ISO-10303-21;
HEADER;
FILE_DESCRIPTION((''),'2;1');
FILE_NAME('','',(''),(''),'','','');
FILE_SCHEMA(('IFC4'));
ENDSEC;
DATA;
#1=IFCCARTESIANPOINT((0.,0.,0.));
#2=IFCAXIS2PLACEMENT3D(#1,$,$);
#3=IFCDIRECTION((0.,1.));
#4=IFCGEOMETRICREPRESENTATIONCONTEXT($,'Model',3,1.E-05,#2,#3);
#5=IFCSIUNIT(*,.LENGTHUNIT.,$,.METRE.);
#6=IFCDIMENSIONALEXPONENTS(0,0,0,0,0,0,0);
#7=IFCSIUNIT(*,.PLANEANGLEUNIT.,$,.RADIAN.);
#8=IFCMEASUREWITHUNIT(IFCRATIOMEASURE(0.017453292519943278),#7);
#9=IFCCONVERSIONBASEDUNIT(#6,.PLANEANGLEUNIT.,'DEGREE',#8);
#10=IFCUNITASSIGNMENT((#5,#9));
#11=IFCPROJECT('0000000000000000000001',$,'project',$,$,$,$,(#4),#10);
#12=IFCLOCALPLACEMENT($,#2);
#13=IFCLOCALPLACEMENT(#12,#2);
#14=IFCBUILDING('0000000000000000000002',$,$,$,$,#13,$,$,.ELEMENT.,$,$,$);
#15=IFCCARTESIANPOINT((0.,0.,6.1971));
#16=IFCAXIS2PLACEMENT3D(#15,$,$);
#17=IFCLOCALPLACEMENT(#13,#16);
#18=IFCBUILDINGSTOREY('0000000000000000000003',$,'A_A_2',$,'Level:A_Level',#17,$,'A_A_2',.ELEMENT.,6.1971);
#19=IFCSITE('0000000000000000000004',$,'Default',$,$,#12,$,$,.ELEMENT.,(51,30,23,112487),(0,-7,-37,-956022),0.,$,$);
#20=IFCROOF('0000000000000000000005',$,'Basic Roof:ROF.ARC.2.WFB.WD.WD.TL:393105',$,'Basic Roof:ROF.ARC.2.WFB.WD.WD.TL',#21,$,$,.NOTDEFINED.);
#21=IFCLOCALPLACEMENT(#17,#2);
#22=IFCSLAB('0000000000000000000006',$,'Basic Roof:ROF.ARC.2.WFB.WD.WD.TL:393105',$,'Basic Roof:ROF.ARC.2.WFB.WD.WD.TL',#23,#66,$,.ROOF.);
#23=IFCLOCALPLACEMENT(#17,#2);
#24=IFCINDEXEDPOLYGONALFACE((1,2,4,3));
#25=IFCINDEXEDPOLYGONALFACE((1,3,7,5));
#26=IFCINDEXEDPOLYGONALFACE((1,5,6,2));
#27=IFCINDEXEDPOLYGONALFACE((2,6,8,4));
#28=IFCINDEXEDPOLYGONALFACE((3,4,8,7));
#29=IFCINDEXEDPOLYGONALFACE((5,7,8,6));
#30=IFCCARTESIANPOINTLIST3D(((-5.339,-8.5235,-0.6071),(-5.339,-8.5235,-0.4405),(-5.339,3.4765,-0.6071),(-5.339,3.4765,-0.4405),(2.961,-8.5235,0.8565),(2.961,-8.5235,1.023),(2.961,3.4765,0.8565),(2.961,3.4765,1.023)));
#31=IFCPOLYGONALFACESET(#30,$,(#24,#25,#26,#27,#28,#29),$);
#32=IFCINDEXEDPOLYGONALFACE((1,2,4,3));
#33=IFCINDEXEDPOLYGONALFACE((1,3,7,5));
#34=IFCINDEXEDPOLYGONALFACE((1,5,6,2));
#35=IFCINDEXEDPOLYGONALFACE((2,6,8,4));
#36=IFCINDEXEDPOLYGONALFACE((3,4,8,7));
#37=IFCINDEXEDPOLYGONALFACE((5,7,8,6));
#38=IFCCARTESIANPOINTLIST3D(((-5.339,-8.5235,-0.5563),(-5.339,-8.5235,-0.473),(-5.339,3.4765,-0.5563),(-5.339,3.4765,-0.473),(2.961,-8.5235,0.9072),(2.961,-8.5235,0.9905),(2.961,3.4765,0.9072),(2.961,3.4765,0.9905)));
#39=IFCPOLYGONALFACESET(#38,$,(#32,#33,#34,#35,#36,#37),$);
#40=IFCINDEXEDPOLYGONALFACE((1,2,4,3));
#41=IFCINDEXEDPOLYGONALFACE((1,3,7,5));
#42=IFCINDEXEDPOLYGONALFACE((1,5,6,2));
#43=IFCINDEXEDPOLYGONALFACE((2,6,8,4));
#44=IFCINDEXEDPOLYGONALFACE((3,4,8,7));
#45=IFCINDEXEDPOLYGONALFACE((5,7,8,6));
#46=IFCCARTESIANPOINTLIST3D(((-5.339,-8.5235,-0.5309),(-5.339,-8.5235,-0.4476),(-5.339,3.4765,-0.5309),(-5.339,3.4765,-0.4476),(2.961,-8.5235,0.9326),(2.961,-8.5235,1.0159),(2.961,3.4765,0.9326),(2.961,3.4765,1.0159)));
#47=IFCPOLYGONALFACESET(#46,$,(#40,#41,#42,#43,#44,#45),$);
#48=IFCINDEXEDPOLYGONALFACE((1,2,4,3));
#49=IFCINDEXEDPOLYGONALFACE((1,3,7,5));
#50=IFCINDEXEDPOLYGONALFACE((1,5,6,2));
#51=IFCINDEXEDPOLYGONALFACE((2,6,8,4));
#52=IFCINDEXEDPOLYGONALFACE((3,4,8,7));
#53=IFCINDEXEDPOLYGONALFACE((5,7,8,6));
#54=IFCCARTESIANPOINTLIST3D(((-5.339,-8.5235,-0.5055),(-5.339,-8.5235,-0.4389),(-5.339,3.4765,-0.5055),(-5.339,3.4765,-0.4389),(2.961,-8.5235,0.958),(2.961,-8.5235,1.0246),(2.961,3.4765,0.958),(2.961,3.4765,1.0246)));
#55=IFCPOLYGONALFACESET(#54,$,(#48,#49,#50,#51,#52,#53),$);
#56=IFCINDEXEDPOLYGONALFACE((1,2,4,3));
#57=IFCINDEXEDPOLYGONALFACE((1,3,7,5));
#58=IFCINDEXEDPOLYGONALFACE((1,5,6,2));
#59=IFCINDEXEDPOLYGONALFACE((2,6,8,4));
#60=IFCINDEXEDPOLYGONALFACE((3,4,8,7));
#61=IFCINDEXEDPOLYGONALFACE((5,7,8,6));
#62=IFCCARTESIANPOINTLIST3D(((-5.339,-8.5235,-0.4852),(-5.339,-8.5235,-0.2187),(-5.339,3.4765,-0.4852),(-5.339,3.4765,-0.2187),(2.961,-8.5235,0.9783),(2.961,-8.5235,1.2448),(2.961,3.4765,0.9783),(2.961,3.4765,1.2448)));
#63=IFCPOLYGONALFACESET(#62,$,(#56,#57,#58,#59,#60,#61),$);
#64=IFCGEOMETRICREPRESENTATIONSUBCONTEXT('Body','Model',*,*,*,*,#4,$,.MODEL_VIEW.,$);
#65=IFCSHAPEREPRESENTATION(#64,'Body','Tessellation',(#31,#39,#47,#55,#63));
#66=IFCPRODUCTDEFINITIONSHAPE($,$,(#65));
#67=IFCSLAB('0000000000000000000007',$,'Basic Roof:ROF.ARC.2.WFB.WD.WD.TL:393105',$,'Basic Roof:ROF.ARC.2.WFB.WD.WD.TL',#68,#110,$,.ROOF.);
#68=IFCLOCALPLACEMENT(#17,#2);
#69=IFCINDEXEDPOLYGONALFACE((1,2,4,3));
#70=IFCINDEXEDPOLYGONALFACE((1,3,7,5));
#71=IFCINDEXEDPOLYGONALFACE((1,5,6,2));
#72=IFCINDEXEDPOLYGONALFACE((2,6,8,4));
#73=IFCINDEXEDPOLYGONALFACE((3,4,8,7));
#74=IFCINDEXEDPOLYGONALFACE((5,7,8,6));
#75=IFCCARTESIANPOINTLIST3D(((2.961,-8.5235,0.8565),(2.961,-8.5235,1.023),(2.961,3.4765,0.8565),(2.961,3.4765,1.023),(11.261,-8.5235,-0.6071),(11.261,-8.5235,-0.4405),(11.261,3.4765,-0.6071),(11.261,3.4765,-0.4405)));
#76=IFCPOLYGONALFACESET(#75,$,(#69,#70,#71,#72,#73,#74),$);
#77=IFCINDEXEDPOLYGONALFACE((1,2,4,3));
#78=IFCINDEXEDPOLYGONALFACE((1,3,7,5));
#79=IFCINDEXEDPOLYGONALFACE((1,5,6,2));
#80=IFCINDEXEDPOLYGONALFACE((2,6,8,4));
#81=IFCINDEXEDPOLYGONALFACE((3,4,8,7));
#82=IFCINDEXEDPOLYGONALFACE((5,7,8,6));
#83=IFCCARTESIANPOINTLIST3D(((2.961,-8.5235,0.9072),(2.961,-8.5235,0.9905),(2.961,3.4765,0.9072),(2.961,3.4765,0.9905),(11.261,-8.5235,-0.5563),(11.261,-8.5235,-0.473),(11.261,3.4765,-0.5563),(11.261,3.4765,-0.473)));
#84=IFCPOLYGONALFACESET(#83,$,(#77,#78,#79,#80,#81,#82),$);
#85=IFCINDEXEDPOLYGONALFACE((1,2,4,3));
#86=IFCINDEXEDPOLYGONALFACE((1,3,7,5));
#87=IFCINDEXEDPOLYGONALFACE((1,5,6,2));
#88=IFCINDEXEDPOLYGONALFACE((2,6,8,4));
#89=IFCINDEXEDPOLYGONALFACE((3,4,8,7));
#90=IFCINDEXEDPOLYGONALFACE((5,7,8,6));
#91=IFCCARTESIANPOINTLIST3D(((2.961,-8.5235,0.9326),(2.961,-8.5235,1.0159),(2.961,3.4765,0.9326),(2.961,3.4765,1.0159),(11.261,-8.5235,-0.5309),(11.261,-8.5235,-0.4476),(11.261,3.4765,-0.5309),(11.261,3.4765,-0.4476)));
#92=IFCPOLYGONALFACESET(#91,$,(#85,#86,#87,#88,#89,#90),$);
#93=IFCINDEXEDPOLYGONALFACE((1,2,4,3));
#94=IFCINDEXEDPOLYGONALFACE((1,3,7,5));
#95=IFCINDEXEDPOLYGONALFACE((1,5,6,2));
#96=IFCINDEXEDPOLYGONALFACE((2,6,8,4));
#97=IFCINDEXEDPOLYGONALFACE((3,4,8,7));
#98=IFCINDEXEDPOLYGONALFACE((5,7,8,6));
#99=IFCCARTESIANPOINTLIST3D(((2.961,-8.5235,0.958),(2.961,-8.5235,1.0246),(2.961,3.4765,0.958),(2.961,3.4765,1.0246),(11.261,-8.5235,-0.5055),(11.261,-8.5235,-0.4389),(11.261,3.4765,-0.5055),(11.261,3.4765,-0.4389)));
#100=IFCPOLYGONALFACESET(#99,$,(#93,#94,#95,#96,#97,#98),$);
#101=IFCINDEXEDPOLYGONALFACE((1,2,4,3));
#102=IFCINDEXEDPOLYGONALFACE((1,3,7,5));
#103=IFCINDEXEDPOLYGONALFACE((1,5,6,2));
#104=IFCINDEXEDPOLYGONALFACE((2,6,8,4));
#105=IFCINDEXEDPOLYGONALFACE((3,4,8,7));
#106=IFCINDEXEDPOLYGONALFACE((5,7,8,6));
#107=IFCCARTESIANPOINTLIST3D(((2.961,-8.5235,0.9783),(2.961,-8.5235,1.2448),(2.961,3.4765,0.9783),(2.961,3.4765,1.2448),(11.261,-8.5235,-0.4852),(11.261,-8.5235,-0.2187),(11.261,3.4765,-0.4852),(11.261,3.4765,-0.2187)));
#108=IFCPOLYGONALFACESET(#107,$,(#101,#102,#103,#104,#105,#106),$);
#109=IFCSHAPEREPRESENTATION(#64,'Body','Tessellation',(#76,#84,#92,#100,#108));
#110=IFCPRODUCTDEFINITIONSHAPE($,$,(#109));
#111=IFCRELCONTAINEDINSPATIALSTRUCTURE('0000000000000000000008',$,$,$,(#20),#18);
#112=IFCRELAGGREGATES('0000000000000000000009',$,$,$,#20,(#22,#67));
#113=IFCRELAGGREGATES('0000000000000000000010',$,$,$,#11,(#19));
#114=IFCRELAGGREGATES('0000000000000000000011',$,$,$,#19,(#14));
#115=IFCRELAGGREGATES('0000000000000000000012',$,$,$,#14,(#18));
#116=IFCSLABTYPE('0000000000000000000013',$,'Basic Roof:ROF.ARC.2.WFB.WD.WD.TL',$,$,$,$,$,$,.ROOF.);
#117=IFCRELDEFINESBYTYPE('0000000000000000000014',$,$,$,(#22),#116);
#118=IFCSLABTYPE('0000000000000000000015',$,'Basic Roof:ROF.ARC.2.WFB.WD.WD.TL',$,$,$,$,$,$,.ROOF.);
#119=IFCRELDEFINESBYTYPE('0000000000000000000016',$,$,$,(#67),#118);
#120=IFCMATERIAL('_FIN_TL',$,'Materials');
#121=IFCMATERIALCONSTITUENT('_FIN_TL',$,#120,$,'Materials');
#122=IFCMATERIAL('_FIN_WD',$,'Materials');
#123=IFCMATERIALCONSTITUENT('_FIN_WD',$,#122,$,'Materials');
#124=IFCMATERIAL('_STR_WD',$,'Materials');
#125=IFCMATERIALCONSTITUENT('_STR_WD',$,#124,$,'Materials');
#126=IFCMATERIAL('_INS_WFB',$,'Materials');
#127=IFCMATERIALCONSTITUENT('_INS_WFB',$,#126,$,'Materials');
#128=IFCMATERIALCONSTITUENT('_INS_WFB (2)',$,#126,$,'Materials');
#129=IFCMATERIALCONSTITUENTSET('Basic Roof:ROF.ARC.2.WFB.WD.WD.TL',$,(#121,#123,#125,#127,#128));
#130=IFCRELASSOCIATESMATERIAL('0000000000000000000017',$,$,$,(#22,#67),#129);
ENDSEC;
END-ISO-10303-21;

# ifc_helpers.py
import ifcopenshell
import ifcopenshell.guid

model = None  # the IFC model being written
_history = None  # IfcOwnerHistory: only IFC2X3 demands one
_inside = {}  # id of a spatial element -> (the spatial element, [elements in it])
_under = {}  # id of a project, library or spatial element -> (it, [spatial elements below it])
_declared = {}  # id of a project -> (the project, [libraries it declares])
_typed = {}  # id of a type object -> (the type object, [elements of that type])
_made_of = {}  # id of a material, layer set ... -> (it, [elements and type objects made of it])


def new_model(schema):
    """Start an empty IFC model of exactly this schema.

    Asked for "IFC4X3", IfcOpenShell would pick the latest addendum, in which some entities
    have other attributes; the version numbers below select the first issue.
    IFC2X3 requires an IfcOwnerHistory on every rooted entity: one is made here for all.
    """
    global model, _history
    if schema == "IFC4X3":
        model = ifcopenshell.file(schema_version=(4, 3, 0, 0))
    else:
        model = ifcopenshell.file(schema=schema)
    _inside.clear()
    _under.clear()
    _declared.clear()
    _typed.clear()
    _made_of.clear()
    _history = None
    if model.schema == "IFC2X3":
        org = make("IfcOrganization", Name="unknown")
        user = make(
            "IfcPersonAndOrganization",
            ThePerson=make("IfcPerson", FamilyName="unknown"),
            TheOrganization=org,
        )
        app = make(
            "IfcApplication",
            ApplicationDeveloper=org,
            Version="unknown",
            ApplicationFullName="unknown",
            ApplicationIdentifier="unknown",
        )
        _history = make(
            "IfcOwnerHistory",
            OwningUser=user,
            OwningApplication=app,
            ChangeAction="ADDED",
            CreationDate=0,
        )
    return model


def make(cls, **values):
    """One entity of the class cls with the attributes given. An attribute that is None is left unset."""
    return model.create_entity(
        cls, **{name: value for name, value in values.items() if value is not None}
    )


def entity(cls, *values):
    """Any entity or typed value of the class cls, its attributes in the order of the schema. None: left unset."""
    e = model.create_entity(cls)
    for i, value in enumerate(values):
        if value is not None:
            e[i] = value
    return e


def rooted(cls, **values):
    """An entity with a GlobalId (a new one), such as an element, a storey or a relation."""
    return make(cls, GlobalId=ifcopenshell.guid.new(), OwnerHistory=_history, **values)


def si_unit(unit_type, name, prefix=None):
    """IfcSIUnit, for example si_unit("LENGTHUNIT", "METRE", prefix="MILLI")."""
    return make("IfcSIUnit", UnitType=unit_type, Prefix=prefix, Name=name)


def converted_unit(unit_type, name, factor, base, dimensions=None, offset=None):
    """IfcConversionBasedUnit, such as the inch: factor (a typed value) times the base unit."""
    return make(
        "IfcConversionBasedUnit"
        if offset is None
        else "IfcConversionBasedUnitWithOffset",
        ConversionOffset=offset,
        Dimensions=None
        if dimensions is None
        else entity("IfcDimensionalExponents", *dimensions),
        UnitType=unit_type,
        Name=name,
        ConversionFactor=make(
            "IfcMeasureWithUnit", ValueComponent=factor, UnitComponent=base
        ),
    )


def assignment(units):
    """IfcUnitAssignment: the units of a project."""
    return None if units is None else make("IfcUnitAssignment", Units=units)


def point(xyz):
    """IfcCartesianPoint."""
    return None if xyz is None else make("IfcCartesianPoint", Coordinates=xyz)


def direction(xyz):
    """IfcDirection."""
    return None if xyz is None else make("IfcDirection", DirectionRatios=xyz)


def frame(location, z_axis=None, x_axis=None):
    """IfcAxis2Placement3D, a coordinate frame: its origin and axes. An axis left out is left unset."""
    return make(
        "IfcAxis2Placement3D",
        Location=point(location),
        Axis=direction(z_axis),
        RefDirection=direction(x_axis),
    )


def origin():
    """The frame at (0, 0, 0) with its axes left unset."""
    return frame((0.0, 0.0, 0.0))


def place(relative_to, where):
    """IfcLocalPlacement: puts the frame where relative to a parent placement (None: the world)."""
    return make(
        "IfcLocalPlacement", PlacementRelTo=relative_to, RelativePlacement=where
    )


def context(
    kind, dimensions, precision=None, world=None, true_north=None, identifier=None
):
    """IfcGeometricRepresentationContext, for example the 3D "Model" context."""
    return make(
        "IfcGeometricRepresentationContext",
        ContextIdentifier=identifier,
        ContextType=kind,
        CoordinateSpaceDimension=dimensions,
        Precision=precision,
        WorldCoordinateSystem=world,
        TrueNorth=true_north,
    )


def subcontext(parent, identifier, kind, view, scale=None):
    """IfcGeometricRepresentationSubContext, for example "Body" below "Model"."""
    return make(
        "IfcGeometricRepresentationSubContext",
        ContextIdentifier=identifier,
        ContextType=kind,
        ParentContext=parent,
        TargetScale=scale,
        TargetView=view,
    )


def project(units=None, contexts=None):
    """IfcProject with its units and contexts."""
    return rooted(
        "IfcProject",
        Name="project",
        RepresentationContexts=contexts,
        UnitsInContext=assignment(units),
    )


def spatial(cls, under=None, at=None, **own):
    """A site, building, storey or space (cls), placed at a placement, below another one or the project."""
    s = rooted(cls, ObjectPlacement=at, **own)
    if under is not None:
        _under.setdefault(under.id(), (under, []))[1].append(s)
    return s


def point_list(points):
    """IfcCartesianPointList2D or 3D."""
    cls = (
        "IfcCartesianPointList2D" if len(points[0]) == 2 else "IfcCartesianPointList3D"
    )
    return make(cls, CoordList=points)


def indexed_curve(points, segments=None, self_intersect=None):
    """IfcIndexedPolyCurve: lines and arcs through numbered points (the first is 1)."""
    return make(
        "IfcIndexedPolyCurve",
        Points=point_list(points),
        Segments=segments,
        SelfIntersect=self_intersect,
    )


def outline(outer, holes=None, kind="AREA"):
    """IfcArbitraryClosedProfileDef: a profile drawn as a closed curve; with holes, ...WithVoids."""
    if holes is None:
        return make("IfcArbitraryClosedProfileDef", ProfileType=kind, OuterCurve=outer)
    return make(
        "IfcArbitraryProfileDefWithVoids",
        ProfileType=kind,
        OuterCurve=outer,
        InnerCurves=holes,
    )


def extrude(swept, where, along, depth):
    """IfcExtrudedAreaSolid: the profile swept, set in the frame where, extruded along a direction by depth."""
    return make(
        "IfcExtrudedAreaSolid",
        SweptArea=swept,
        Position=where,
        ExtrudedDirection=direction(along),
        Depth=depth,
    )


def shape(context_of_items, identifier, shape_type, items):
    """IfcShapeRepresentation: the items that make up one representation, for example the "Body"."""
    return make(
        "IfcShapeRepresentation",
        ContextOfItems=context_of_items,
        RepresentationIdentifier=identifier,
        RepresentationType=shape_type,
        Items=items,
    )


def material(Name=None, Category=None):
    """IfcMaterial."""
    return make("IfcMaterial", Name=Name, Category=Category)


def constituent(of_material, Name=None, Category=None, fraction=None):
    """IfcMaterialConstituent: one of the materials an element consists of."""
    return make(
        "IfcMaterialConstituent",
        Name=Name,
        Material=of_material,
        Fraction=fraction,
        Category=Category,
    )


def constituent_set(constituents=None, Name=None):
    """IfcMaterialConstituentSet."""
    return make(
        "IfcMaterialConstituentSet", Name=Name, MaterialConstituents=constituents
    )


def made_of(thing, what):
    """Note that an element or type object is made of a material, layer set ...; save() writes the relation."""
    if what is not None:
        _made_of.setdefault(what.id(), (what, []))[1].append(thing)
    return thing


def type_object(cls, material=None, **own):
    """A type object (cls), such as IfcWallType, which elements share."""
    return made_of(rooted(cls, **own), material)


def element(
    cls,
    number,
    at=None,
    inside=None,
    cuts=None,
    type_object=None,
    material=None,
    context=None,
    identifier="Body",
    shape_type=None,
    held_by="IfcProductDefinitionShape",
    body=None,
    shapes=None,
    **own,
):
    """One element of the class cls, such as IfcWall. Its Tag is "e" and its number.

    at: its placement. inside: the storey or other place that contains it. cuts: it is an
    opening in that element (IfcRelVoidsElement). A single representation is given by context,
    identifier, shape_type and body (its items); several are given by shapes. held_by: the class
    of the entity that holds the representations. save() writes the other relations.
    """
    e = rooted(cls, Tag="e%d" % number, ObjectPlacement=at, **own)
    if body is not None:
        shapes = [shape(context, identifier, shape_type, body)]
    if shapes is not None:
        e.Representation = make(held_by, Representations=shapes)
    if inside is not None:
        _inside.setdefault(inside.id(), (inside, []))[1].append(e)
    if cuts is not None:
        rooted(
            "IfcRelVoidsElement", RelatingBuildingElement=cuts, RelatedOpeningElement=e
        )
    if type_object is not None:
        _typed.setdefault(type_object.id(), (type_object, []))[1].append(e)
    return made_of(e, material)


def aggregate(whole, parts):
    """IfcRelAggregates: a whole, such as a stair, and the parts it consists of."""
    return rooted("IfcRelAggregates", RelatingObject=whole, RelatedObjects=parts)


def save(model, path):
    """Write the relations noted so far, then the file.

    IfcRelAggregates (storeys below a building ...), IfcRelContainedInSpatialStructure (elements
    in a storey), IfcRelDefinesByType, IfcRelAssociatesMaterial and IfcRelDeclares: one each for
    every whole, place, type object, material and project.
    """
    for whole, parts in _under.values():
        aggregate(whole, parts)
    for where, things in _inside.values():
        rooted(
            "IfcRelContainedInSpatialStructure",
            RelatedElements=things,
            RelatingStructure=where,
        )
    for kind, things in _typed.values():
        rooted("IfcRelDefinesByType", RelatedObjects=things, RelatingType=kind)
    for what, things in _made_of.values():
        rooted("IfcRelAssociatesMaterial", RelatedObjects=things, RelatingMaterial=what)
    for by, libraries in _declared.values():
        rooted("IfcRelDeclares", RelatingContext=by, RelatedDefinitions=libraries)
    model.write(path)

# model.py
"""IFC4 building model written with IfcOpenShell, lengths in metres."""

from ifc_helpers import new_model, entity, si_unit, converted_unit, direction, frame, origin, place, context, subcontext, project, spatial, indexed_curve, outline, extrude, material, constituent, constituent_set, type_object, element, aggregate, save


model = new_model("IFC4")

# Units and contexts
model_context = context("Model", 3, precision=1e-05, world=origin(), true_north=direction((0.0, 1.0)))
body_context = subcontext(model_context, "Body", "Model", "MODEL_VIEW")
ifc_project = project(units=[si_unit("LENGTHUNIT", "METRE"), converted_unit("PLANEANGLEUNIT", "DEGREE", entity("IfcRatioMeasure", 0.017453292519943278), si_unit("PLANEANGLEUNIT", "RADIAN"), dimensions=[0, 0, 0, 0, 0, 0, 0])], contexts=[model_context])

# Site, building, storey
site_placement = place(None, origin())
site = spatial("IfcSite", under=ifc_project, at=site_placement, Name="Default", CompositionType="ELEMENT", RefLatitude=(51, 30, 23, 112487), RefLongitude=(0, -7, -37, -956022), RefElevation=0.0)
building_placement = place(site_placement, origin())
building = spatial("IfcBuilding", under=site, at=building_placement, CompositionType="ELEMENT")
storey_placement = place(building_placement, frame((0.0, 0.0, 6.1971)))
storey = spatial("IfcBuildingStorey", under=building, at=storey_placement, Name="A_A_2", ObjectType="Level:A_Level", LongName="A_A_2", CompositionType="ELEMENT", Elevation=6.1971)

# Roof, slabs
roof_placement = place(storey_placement, frame((-5.339, -8.5235, -0.6071)))
roof = element("IfcRoof", 1, at=roof_placement, inside=storey, Name="Basic Roof:ROF.ARC.2.WFB.WD.WD.TL:393105", ObjectType="Basic Roof:ROF.ARC.2.WFB.WD.WD.TL", PredefinedType="NOTDEFINED")
ifc_material_1 = material(Name="_FIN_TL", Category="Materials")
ifc_constituent_1 = constituent(ifc_material_1, Name="_FIN_TL", Category="Materials")
ifc_material_2 = material(Name="_FIN_WD", Category="Materials")
ifc_constituent_2 = constituent(ifc_material_2, Name="_FIN_WD", Category="Materials")
ifc_material_3 = material(Name="_STR_WD", Category="Materials")
ifc_constituent_3 = constituent(ifc_material_3, Name="_STR_WD", Category="Materials")
ifc_material_4 = material(Name="_INS_WFB", Category="Materials")
ifc_constituent_4 = constituent(ifc_material_4, Name="_INS_WFB", Category="Materials")
ifc_constituent_5 = constituent(ifc_material_4, Name="_INS_WFB (2)", Category="Materials")
ifc_constituent_set = constituent_set(constituents=[ifc_constituent_1, ifc_constituent_2, ifc_constituent_3, ifc_constituent_4, ifc_constituent_5], Name="Basic Roof:ROF.ARC.2.WFB.WD.WD.TL")
slab_type_1 = type_object("IfcSlabType", Name="Basic Roof:ROF.ARC.2.WFB.WD.WD.TL", PredefinedType="ROOF")
slab_1_placement = place(roof_placement, origin())
slab_1 = element("IfcSlab", 2, at=slab_1_placement, type_object=slab_type_1, material=ifc_constituent_set, Name="Basic Roof:ROF.ARC.2.WFB.WD.WD.TL:393105", ObjectType="Basic Roof:ROF.ARC.2.WFB.WD.WD.TL", PredefinedType="ROOF", context=body_context, shape_type="SweptSolid", body=[
    extrude(outline(indexed_curve([(-4.214, -6.0), (4.214, -6.0), (4.214, 6.0), (-4.214, 6.0), (-4.214, -6.0)], self_intersect=False)), frame((4.15, 6.0, 0.7318), z_axis=(-0.173648, 0.0, 0.984808), x_axis=(0.984808, 0.0, 0.173648)), (0.173648, 0.0, 0.984808), 0.1666),
    extrude(outline(indexed_curve([(-4.214, -6.0), (4.214, -6.0), (4.214, 6.0), (-4.214, 6.0), (-4.214, -6.0)], self_intersect=False)), frame((4.15, 6.0, 0.7825), z_axis=(-0.173648, 0.0, 0.984808), x_axis=(0.984808, 0.0, 0.173648)), (0.173648, 0.0, 0.984808), 0.0833),
    extrude(outline(indexed_curve([(-4.214, -6.0), (4.214, -6.0), (4.214, 6.0), (-4.214, 6.0), (-4.214, -6.0)], self_intersect=False)), frame((4.15, 6.0, 0.8079), z_axis=(-0.173648, 0.0, 0.984808), x_axis=(0.984808, 0.0, 0.173648)), (0.173648, 0.0, 0.984808), 0.0833),
    extrude(outline(indexed_curve([(-4.214, -6.0), (4.214, -6.0), (4.214, 6.0), (-4.214, 6.0), (-4.214, -6.0)], self_intersect=False)), frame((4.15, 6.0, 0.8333), z_axis=(-0.173648, 0.0, 0.984808), x_axis=(0.984808, 0.0, 0.173648)), (0.173648, 0.0, 0.984808), 0.0666),
    extrude(outline(indexed_curve([(-4.214, -6.0), (4.214, -6.0), (4.214, 6.0), (-4.214, 6.0), (-4.214, -6.0)], self_intersect=False)), frame((4.15, 6.0, 0.8536), z_axis=(-0.173648, 0.0, 0.984808), x_axis=(0.984808, 0.0, 0.173648)), (0.173648, 0.0, 0.984808), 0.2665),
])
slab_type_2 = type_object("IfcSlabType", Name="Basic Roof:ROF.ARC.2.WFB.WD.WD.TL", PredefinedType="ROOF")
slab_2_placement = place(roof_placement, origin())
slab_2 = element("IfcSlab", 3, at=slab_2_placement, type_object=slab_type_2, material=ifc_constituent_set, Name="Basic Roof:ROF.ARC.2.WFB.WD.WD.TL:393105", ObjectType="Basic Roof:ROF.ARC.2.WFB.WD.WD.TL", PredefinedType="ROOF", context=body_context, shape_type="SweptSolid", body=[
    extrude(outline(indexed_curve([(-4.214, 6.0), (-4.214, -6.0), (4.214, -6.0), (4.214, 6.0), (-4.214, 6.0)], self_intersect=False)), frame((12.45, 6.0, 0.7318), z_axis=(0.173648, 0.0, 0.984808), x_axis=(0.984808, 0.0, -0.173648)), (-0.173648, 0.0, 0.984808), 0.1666),
    extrude(outline(indexed_curve([(-4.214, 6.0), (-4.214, -6.0), (4.214, -6.0), (4.214, 6.0), (-4.214, 6.0)], self_intersect=False)), frame((12.45, 6.0, 0.7825), z_axis=(0.173648, 0.0, 0.984808), x_axis=(0.984808, 0.0, -0.173648)), (-0.173648, 0.0, 0.984808), 0.0833),
    extrude(outline(indexed_curve([(-4.214, 6.0), (-4.214, -6.0), (4.214, -6.0), (4.214, 6.0), (-4.214, 6.0)], self_intersect=False)), frame((12.45, 6.0, 0.8079), z_axis=(0.173648, 0.0, 0.984808), x_axis=(0.984808, 0.0, -0.173648)), (-0.173648, 0.0, 0.984808), 0.0833),
    extrude(outline(indexed_curve([(-4.214, 6.0), (-4.214, -6.0), (4.214, -6.0), (4.214, 6.0), (-4.214, 6.0)], self_intersect=False)), frame((12.45, 6.0, 0.8333), z_axis=(0.173648, 0.0, 0.984808), x_axis=(0.984808, 0.0, -0.173648)), (-0.173648, 0.0, 0.984808), 0.0666),
    extrude(outline(indexed_curve([(-4.214, 6.0), (-4.214, -6.0), (4.214, -6.0), (4.214, 6.0), (-4.214, 6.0)], self_intersect=False)), frame((12.45, 6.0, 0.8536), z_axis=(0.173648, 0.0, 0.984808), x_axis=(0.984808, 0.0, -0.173648)), (-0.173648, 0.0, 0.984808), 0.2665),
])
aggregate(roof, [slab_1, slab_2])

save(model, "model.ifc")
